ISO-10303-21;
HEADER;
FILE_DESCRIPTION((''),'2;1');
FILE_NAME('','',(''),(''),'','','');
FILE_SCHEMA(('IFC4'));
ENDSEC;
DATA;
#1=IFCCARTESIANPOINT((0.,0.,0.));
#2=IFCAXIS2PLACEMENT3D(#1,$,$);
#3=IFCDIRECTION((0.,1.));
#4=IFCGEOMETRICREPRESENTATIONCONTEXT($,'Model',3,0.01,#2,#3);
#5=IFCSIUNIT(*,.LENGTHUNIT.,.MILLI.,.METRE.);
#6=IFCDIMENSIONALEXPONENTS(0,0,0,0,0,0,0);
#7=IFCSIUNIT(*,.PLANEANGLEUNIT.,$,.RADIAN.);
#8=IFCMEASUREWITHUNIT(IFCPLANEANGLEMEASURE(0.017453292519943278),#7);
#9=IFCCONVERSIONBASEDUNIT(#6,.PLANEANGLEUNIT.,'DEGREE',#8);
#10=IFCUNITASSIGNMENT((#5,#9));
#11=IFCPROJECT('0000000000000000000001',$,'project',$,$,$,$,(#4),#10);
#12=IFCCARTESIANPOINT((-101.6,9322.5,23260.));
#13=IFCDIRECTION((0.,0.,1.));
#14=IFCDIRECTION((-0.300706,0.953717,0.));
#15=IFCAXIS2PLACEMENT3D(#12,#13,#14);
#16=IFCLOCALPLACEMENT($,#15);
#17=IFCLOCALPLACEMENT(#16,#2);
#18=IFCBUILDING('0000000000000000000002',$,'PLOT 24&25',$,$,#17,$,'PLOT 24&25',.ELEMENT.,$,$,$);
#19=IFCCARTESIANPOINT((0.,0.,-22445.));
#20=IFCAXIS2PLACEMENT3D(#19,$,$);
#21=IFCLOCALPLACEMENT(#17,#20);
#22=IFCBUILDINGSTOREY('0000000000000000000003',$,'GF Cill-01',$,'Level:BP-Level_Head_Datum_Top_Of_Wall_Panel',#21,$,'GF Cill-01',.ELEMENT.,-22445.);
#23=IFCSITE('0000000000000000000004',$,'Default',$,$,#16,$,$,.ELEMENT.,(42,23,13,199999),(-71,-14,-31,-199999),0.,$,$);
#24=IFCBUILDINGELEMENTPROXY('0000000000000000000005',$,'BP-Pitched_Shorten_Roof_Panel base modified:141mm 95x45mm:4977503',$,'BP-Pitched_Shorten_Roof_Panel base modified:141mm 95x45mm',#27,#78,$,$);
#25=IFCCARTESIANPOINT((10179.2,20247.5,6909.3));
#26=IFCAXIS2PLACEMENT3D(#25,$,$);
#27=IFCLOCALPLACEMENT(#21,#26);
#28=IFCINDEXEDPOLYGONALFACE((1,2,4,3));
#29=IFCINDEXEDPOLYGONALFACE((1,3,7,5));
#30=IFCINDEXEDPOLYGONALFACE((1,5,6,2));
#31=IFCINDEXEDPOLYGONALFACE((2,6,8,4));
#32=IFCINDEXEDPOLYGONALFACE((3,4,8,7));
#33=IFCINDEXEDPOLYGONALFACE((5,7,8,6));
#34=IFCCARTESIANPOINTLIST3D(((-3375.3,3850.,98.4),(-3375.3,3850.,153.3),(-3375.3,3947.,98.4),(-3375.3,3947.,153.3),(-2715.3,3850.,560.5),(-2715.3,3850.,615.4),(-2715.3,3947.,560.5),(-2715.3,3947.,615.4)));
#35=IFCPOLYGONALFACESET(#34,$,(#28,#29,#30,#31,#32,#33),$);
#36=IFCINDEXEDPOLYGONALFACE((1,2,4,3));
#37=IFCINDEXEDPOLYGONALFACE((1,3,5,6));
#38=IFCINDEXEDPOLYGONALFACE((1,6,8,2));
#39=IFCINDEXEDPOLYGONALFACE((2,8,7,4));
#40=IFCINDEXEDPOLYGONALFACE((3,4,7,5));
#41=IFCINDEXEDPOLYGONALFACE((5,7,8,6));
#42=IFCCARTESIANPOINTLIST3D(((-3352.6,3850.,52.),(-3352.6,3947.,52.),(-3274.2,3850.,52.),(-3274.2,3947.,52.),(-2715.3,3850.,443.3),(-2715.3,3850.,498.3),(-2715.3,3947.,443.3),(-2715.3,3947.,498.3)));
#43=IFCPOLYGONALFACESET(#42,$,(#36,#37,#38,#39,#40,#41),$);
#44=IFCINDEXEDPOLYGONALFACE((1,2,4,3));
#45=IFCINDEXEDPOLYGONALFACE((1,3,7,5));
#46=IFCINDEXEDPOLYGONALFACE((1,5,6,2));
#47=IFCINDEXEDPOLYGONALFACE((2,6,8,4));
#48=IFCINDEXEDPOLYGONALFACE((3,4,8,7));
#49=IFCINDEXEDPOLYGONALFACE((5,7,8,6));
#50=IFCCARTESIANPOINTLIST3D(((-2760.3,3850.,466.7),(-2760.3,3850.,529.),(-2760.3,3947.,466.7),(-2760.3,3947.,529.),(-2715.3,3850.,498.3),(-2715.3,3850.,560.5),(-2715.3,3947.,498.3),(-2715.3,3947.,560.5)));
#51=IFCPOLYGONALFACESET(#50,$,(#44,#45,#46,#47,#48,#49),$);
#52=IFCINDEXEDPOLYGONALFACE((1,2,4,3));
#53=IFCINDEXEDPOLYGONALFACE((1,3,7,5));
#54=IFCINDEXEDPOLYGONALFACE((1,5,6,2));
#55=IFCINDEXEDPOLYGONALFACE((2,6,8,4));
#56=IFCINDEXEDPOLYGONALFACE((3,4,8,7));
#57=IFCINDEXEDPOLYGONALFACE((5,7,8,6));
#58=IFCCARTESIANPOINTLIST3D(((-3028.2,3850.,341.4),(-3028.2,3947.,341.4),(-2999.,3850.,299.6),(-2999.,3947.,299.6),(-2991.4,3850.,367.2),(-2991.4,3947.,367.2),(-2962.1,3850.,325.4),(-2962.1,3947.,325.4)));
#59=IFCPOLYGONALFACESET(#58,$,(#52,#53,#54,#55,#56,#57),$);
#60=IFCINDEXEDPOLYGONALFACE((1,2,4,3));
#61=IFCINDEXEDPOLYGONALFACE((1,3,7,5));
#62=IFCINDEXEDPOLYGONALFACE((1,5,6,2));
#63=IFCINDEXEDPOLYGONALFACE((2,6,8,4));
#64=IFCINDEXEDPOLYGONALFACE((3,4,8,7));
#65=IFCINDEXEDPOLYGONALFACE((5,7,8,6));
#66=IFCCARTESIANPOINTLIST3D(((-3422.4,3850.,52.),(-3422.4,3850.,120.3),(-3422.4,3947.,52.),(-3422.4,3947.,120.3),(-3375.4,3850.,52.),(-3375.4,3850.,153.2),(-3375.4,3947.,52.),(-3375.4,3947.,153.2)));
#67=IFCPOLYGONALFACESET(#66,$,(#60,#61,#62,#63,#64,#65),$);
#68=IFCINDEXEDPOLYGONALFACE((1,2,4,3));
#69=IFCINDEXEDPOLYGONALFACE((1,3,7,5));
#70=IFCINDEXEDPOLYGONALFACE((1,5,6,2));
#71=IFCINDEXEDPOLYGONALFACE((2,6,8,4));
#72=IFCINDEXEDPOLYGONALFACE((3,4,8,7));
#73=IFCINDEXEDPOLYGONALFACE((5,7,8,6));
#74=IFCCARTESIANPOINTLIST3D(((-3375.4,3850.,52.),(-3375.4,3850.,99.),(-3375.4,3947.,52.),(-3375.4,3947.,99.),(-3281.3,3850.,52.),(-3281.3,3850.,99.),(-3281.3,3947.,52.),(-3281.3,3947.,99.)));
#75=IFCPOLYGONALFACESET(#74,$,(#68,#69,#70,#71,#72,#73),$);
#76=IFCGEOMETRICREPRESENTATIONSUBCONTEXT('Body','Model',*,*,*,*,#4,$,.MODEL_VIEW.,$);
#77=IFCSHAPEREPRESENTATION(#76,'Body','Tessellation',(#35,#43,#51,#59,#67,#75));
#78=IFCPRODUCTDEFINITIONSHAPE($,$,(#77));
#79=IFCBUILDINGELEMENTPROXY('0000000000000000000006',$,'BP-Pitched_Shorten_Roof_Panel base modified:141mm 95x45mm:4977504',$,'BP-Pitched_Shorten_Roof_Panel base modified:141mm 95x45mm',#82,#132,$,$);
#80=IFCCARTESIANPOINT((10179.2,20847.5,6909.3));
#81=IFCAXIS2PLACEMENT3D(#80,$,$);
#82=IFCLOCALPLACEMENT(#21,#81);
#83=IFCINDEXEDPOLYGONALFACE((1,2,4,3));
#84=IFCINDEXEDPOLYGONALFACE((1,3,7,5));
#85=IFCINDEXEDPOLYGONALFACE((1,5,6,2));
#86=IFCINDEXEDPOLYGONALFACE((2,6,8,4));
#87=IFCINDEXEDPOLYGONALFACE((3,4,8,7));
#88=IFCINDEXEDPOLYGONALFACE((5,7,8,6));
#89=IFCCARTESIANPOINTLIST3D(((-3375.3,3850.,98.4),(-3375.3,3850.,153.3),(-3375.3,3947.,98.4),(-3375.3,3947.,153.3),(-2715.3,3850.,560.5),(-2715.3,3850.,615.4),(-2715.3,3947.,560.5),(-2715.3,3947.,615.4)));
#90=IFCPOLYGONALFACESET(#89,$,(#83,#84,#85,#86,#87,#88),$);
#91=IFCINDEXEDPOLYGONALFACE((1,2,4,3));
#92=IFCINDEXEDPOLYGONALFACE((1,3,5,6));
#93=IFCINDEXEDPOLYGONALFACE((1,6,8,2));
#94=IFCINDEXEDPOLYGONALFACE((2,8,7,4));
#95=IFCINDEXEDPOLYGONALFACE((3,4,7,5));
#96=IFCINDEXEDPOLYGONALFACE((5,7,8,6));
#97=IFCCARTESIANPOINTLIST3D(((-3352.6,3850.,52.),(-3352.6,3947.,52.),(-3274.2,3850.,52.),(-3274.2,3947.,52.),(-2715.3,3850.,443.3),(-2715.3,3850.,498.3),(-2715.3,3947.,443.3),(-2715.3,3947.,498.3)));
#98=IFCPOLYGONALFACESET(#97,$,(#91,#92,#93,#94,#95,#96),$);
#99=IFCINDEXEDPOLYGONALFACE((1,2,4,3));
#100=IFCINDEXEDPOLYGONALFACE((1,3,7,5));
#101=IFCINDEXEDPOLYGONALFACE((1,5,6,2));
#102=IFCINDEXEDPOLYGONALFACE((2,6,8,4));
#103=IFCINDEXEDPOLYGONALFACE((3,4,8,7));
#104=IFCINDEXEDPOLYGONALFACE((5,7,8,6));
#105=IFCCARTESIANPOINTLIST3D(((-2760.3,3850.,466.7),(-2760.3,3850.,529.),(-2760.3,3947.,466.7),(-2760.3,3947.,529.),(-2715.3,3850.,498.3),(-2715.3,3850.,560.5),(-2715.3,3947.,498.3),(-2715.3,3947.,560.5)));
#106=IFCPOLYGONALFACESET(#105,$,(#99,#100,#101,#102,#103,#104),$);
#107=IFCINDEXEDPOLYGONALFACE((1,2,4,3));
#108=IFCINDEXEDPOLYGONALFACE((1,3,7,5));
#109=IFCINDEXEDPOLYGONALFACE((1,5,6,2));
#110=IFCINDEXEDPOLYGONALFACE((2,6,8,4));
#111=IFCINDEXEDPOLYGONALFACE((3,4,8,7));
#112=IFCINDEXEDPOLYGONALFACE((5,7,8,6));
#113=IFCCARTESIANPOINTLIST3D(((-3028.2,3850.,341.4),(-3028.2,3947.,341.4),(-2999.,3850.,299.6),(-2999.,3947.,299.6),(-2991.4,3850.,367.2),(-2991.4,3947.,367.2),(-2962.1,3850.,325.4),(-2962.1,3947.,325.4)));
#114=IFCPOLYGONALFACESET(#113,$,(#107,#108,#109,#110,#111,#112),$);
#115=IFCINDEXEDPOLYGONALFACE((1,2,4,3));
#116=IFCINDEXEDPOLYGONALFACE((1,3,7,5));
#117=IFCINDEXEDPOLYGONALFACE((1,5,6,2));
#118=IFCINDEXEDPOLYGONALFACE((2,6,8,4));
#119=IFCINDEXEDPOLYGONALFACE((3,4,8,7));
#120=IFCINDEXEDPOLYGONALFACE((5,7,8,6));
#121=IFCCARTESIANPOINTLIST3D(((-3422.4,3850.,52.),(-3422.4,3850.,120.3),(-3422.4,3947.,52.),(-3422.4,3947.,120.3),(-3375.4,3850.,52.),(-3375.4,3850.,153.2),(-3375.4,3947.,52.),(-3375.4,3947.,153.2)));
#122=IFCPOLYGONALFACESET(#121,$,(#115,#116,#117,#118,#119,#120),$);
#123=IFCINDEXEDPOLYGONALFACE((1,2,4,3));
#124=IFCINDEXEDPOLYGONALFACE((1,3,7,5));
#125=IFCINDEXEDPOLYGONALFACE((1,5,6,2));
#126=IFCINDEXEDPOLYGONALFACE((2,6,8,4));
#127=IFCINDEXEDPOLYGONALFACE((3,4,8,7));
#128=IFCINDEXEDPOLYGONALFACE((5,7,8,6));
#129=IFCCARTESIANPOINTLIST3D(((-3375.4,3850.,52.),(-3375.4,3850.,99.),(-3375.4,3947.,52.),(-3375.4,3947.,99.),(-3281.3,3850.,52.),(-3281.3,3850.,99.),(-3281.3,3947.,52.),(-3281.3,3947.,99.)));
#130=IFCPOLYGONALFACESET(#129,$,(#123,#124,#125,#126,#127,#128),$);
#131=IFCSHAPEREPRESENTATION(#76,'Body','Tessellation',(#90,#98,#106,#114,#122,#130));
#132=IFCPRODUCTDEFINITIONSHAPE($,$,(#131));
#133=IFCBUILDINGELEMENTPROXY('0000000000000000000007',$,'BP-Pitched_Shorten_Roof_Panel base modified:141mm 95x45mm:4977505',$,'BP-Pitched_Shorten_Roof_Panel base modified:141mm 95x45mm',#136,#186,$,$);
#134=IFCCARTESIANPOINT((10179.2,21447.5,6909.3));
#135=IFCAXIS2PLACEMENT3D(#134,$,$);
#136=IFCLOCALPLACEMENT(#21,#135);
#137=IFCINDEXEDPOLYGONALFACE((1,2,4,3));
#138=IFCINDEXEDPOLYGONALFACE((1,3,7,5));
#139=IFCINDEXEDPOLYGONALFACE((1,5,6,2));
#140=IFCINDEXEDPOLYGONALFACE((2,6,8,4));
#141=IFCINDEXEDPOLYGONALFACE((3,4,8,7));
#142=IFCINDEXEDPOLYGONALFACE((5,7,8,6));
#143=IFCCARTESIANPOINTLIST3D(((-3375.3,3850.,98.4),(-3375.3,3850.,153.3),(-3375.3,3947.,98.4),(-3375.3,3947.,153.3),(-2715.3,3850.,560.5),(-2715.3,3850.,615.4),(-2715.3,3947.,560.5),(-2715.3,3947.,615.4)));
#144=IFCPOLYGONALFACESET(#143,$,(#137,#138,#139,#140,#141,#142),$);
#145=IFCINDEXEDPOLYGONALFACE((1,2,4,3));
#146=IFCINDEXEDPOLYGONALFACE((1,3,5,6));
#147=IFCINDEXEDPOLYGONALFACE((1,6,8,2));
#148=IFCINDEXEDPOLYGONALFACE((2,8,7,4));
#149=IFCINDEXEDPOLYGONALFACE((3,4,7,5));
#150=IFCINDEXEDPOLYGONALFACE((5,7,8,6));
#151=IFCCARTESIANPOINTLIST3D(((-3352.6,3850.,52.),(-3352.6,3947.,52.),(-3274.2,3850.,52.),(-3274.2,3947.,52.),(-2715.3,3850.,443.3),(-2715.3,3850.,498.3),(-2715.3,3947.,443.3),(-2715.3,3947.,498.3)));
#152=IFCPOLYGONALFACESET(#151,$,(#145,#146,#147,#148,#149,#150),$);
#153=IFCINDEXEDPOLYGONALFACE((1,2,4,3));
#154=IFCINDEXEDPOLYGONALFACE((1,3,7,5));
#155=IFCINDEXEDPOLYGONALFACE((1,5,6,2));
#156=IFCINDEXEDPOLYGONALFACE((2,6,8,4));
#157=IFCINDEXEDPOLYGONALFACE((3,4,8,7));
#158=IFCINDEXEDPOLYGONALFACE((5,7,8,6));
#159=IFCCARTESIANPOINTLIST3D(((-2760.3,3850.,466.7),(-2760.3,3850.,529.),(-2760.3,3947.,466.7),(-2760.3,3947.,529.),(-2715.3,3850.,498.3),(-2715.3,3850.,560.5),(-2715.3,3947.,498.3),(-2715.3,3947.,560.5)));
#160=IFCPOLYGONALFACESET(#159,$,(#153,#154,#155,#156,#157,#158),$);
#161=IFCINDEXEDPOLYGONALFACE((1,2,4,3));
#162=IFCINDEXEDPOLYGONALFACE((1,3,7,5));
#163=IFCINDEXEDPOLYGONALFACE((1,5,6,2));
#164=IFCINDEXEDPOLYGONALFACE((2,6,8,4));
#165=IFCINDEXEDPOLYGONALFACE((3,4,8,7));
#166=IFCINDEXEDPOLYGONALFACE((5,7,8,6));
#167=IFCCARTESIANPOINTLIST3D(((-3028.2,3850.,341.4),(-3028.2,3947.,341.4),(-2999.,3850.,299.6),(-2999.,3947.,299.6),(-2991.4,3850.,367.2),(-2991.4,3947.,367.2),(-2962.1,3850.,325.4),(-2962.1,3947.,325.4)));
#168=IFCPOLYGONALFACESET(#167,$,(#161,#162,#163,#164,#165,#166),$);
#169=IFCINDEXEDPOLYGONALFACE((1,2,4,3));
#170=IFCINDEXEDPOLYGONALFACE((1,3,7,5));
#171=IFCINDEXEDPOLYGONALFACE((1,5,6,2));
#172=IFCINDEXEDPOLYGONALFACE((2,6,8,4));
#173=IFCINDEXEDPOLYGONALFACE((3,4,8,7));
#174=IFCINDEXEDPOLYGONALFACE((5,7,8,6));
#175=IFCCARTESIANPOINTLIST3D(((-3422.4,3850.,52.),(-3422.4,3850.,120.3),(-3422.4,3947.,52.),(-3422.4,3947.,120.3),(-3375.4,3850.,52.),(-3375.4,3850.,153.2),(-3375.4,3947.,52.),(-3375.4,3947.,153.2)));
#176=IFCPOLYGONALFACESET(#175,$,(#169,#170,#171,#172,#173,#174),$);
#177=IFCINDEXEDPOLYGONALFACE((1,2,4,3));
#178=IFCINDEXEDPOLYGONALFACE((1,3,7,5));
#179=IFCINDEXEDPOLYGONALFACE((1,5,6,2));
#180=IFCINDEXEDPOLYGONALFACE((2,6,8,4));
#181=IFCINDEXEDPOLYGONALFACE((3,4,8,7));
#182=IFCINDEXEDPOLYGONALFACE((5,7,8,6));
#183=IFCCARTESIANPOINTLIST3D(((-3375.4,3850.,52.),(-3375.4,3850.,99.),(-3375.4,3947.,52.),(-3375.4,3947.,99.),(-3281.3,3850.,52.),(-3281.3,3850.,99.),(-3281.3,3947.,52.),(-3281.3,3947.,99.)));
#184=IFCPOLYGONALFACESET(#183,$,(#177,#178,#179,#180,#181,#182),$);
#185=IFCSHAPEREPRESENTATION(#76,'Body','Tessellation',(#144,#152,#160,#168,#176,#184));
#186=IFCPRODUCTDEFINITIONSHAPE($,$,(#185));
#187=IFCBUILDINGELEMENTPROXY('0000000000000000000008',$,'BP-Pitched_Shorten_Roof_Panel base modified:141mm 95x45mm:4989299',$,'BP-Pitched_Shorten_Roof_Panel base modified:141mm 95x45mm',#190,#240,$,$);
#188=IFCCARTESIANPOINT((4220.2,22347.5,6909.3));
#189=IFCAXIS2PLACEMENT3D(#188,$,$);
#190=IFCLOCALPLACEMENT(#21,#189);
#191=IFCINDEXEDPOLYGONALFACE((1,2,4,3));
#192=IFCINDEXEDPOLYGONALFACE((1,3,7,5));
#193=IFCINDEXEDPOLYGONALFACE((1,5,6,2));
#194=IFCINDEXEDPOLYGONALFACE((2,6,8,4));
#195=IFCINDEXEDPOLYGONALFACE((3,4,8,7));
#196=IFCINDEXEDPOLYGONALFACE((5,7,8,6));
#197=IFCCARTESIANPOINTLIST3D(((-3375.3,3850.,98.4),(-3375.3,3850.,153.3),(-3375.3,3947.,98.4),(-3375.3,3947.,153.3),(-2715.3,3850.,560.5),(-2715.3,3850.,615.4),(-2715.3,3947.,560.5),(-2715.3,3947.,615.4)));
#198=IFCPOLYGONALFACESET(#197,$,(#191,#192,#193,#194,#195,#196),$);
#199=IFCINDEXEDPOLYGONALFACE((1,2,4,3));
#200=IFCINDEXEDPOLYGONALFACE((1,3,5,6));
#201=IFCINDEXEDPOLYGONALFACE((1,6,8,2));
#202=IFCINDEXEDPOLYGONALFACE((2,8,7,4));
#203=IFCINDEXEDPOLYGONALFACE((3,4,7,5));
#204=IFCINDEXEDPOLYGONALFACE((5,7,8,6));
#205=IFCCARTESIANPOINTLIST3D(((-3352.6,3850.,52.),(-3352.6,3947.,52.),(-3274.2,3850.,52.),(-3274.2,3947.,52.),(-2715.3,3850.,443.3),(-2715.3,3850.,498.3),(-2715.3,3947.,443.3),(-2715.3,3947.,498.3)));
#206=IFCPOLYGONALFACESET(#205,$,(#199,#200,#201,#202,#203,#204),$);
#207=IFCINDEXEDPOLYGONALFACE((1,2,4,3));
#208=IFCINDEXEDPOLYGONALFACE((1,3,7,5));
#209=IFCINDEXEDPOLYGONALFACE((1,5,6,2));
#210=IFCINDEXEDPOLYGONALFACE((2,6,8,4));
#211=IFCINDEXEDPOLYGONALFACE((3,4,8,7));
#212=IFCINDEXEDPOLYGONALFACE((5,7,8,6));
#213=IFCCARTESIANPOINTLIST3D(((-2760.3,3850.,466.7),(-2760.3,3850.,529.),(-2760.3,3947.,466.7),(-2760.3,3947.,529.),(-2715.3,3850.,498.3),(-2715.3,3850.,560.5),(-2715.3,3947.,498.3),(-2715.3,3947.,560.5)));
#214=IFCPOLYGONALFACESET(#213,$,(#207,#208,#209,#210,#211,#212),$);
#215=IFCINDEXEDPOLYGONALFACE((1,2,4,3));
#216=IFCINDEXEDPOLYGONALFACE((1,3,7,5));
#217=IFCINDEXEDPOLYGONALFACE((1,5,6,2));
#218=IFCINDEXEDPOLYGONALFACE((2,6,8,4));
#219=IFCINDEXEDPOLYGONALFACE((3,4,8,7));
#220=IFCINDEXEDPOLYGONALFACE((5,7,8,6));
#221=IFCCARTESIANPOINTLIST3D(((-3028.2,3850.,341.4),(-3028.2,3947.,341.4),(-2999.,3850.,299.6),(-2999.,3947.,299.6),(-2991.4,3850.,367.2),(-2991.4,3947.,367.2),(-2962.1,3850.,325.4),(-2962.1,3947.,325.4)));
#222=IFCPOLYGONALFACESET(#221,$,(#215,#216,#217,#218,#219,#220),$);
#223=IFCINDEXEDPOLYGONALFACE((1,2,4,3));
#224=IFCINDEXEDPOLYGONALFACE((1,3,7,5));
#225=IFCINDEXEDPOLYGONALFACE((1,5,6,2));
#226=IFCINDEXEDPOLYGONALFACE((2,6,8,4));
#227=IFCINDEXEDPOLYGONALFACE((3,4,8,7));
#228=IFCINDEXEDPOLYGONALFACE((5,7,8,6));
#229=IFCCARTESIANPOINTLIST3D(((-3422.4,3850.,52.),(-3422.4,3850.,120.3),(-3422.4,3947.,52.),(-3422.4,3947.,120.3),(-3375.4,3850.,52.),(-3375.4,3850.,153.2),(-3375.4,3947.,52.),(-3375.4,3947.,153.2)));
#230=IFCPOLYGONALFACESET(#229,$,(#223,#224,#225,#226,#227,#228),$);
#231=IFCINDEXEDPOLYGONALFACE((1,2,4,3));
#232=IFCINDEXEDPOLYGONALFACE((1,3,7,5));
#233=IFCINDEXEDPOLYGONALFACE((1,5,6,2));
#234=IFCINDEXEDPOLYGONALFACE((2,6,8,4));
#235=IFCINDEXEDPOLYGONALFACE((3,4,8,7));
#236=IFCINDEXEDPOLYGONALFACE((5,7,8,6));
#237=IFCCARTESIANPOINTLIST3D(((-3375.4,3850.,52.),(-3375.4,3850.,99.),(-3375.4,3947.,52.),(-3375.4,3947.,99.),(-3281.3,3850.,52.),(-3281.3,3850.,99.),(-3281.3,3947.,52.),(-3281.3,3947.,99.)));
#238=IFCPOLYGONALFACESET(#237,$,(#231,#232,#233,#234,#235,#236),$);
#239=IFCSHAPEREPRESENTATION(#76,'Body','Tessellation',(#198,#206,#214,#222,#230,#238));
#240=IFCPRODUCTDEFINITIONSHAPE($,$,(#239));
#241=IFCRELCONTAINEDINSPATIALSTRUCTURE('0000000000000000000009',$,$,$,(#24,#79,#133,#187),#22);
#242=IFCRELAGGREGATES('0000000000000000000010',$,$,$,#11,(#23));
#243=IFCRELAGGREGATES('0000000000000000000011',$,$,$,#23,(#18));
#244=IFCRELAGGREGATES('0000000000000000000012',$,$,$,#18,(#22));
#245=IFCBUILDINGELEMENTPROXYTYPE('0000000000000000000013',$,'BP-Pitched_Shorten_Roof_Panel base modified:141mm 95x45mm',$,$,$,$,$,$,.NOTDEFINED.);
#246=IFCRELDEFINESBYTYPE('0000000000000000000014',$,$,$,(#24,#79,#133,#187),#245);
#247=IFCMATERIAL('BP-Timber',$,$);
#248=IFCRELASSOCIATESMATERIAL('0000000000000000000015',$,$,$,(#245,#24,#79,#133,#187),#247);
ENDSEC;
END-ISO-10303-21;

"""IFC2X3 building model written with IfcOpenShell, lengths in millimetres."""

from ifc_helpers import new_model, entity, si_unit, converted_unit, direction, frame, frame_2d, origin, origin_2d_with_axis, place, context, subcontext, project, spatial, polyline, rectangle, outline, extrude, source, transform, mapped, material, type_object, type_shapes, element, save


model = new_model("IFC2X3")

# Units and contexts
model_context = context("Model", 3, precision=0.01, world=origin(), true_north=direction((0.0, 1.0)))
body_context = subcontext(model_context, "Body", "Model", "MODEL_VIEW")
ifc_project = project(units=[si_unit("LENGTHUNIT", "METRE", prefix="MILLI"), converted_unit("PLANEANGLEUNIT", "DEGREE", entity("IfcPlaneAngleMeasure", 0.017453292519943278), si_unit("PLANEANGLEUNIT", "RADIAN"), dimensions=[0, 0, 0, 0, 0, 0, 0])], contexts=[model_context])

# Site, building, storey
site_placement = place(None, frame((-101.6, 9322.5, 23260.0), z_axis=(0.0, 0.0, 1.0), x_axis=(-0.300706, 0.953717, 0.0)))
site = spatial("IfcSite", under=ifc_project, at=site_placement, Name="Default", CompositionType="ELEMENT", RefLatitude=(42, 23, 13, 199999), RefLongitude=(-71, -14, -31, -199999), RefElevation=0.0)
building_placement = place(site_placement, origin())
building = spatial("IfcBuilding", under=site, at=building_placement, Name="PLOT 24&25", LongName="PLOT 24&25", CompositionType="ELEMENT")
storey_placement = place(building_placement, frame((0.0, 0.0, -22445.0)))
storey = spatial("IfcBuildingStorey", under=building, at=storey_placement, Name="GF Cill-01", ObjectType="Level:BP-Level_Head_Datum_Top_Of_Wall_Panel", LongName="GF Cill-01", CompositionType="ELEMENT", Elevation=-22445.0)

# Shared definitions
ifc_material_1 = material(Name="BP-Timber")

# Building element proxies
building_element_proxy_type_1 = type_object("IfcBuildingElementProxyType", Name="BP-Pitched_Shorten_Roof_Panel base modified:141mm 95x45mm", PredefinedType="NOTDEFINED", material=ifc_material_1)
shared_shape_1 = source(origin(), body_context, "Body", "SweptSolid", [
    extrude(outline(polyline([(-258.5, -330.0), (-203.6, -330.0), (258.5, 330.0), (203.6, 330.0), (-258.5, -330.0)])), frame((-3045.3, 3850.0, 356.9), z_axis=(0.0, 1.0, 0.0), x_axis=(0.0, 0.0, -1.0)), (0.0, 0.0, 1.0), 97.0),
    extrude(outline(polyline([(-236.9, -299.0), (-181.9, -299.0), (209.4, 259.8), (209.4, 338.3), (-236.9, -299.0)])), frame((-3014.4, 3850.0, 261.4), z_axis=(0.0, 1.0, 0.0), x_axis=(0.0, 0.0, -1.0)), (0.0, 0.0, 1.0), 97.0),
    extrude(outline(polyline([(-9.6, -25.5), (45.3, -25.5), (9.6, 25.5), (-45.3, 25.5), (-9.6, -25.5)])), frame((-2737.8, 3850.0, 513.6), z_axis=(0.0, 1.0, 0.0), x_axis=(0.819152, 0.0, 0.573576)), (0.0, 0.0, 1.0), 97.0),
    extrude(rectangle(XDim=51.0, YDim=45.0, at=origin_2d_with_axis()), frame((-2995.2, 3850.0, 333.4), z_axis=(0.0, 1.0, 0.0), x_axis=(0.573576, 0.0, -0.819152)), (0.0, 0.0, 1.0), 97.0),
    extrude(outline(polyline([(-58.9, -23.5), (42.4, -23.5), (42.4, 23.5), (-25.9, 23.5), (-58.9, -23.5)])), frame((-3398.9, 3850.0, 94.4), z_axis=(0.0, 1.0, 0.0), x_axis=(0.0, 0.0, -1.0)), (0.0, 0.0, 1.0), 97.0),
    extrude(rectangle(XDim=97.0, YDim=94.1, at=frame_2d((0.0, 0.0), x_axis=(1.0, 0.0))), frame((-3328.4, 3898.5, 52.0), z_axis=(0.0, 0.0, 1.0), x_axis=(0.0, 1.0, 0.0)), (0.0, 0.0, 1.0), 47.0),
])
type_shapes(building_element_proxy_type_1, [shared_shape_1])
for number, where, name in (
    (1, (10179.2, 20247.5, 6909.3), "BP-Pitched_Shorten_Roof_Panel base modified:141mm 95x45mm:4977503"),
    (2, (10179.2, 20847.5, 6909.3), "BP-Pitched_Shorten_Roof_Panel base modified:141mm 95x45mm:4977504"),
    (3, (10179.2, 21447.5, 6909.3), "BP-Pitched_Shorten_Roof_Panel base modified:141mm 95x45mm:4977505"),
    (4, (4220.2, 22347.5, 6909.3), "BP-Pitched_Shorten_Roof_Panel base modified:141mm 95x45mm:4989299"),
):
    element("IfcBuildingElementProxy", number, at=place(storey_placement, frame(where)), inside=storey, type_object=building_element_proxy_type_1, material=ifc_material_1, Name=name, ObjectType="BP-Pitched_Shorten_Roof_Panel base modified:141mm 95x45mm", context=body_context, shape_type="MappedRepresentation", body=[
        mapped(shared_shape_1, transform((0.0, 0.0, 0.0), scale=1.0)),
    ])

save(model, "model.ifc")
